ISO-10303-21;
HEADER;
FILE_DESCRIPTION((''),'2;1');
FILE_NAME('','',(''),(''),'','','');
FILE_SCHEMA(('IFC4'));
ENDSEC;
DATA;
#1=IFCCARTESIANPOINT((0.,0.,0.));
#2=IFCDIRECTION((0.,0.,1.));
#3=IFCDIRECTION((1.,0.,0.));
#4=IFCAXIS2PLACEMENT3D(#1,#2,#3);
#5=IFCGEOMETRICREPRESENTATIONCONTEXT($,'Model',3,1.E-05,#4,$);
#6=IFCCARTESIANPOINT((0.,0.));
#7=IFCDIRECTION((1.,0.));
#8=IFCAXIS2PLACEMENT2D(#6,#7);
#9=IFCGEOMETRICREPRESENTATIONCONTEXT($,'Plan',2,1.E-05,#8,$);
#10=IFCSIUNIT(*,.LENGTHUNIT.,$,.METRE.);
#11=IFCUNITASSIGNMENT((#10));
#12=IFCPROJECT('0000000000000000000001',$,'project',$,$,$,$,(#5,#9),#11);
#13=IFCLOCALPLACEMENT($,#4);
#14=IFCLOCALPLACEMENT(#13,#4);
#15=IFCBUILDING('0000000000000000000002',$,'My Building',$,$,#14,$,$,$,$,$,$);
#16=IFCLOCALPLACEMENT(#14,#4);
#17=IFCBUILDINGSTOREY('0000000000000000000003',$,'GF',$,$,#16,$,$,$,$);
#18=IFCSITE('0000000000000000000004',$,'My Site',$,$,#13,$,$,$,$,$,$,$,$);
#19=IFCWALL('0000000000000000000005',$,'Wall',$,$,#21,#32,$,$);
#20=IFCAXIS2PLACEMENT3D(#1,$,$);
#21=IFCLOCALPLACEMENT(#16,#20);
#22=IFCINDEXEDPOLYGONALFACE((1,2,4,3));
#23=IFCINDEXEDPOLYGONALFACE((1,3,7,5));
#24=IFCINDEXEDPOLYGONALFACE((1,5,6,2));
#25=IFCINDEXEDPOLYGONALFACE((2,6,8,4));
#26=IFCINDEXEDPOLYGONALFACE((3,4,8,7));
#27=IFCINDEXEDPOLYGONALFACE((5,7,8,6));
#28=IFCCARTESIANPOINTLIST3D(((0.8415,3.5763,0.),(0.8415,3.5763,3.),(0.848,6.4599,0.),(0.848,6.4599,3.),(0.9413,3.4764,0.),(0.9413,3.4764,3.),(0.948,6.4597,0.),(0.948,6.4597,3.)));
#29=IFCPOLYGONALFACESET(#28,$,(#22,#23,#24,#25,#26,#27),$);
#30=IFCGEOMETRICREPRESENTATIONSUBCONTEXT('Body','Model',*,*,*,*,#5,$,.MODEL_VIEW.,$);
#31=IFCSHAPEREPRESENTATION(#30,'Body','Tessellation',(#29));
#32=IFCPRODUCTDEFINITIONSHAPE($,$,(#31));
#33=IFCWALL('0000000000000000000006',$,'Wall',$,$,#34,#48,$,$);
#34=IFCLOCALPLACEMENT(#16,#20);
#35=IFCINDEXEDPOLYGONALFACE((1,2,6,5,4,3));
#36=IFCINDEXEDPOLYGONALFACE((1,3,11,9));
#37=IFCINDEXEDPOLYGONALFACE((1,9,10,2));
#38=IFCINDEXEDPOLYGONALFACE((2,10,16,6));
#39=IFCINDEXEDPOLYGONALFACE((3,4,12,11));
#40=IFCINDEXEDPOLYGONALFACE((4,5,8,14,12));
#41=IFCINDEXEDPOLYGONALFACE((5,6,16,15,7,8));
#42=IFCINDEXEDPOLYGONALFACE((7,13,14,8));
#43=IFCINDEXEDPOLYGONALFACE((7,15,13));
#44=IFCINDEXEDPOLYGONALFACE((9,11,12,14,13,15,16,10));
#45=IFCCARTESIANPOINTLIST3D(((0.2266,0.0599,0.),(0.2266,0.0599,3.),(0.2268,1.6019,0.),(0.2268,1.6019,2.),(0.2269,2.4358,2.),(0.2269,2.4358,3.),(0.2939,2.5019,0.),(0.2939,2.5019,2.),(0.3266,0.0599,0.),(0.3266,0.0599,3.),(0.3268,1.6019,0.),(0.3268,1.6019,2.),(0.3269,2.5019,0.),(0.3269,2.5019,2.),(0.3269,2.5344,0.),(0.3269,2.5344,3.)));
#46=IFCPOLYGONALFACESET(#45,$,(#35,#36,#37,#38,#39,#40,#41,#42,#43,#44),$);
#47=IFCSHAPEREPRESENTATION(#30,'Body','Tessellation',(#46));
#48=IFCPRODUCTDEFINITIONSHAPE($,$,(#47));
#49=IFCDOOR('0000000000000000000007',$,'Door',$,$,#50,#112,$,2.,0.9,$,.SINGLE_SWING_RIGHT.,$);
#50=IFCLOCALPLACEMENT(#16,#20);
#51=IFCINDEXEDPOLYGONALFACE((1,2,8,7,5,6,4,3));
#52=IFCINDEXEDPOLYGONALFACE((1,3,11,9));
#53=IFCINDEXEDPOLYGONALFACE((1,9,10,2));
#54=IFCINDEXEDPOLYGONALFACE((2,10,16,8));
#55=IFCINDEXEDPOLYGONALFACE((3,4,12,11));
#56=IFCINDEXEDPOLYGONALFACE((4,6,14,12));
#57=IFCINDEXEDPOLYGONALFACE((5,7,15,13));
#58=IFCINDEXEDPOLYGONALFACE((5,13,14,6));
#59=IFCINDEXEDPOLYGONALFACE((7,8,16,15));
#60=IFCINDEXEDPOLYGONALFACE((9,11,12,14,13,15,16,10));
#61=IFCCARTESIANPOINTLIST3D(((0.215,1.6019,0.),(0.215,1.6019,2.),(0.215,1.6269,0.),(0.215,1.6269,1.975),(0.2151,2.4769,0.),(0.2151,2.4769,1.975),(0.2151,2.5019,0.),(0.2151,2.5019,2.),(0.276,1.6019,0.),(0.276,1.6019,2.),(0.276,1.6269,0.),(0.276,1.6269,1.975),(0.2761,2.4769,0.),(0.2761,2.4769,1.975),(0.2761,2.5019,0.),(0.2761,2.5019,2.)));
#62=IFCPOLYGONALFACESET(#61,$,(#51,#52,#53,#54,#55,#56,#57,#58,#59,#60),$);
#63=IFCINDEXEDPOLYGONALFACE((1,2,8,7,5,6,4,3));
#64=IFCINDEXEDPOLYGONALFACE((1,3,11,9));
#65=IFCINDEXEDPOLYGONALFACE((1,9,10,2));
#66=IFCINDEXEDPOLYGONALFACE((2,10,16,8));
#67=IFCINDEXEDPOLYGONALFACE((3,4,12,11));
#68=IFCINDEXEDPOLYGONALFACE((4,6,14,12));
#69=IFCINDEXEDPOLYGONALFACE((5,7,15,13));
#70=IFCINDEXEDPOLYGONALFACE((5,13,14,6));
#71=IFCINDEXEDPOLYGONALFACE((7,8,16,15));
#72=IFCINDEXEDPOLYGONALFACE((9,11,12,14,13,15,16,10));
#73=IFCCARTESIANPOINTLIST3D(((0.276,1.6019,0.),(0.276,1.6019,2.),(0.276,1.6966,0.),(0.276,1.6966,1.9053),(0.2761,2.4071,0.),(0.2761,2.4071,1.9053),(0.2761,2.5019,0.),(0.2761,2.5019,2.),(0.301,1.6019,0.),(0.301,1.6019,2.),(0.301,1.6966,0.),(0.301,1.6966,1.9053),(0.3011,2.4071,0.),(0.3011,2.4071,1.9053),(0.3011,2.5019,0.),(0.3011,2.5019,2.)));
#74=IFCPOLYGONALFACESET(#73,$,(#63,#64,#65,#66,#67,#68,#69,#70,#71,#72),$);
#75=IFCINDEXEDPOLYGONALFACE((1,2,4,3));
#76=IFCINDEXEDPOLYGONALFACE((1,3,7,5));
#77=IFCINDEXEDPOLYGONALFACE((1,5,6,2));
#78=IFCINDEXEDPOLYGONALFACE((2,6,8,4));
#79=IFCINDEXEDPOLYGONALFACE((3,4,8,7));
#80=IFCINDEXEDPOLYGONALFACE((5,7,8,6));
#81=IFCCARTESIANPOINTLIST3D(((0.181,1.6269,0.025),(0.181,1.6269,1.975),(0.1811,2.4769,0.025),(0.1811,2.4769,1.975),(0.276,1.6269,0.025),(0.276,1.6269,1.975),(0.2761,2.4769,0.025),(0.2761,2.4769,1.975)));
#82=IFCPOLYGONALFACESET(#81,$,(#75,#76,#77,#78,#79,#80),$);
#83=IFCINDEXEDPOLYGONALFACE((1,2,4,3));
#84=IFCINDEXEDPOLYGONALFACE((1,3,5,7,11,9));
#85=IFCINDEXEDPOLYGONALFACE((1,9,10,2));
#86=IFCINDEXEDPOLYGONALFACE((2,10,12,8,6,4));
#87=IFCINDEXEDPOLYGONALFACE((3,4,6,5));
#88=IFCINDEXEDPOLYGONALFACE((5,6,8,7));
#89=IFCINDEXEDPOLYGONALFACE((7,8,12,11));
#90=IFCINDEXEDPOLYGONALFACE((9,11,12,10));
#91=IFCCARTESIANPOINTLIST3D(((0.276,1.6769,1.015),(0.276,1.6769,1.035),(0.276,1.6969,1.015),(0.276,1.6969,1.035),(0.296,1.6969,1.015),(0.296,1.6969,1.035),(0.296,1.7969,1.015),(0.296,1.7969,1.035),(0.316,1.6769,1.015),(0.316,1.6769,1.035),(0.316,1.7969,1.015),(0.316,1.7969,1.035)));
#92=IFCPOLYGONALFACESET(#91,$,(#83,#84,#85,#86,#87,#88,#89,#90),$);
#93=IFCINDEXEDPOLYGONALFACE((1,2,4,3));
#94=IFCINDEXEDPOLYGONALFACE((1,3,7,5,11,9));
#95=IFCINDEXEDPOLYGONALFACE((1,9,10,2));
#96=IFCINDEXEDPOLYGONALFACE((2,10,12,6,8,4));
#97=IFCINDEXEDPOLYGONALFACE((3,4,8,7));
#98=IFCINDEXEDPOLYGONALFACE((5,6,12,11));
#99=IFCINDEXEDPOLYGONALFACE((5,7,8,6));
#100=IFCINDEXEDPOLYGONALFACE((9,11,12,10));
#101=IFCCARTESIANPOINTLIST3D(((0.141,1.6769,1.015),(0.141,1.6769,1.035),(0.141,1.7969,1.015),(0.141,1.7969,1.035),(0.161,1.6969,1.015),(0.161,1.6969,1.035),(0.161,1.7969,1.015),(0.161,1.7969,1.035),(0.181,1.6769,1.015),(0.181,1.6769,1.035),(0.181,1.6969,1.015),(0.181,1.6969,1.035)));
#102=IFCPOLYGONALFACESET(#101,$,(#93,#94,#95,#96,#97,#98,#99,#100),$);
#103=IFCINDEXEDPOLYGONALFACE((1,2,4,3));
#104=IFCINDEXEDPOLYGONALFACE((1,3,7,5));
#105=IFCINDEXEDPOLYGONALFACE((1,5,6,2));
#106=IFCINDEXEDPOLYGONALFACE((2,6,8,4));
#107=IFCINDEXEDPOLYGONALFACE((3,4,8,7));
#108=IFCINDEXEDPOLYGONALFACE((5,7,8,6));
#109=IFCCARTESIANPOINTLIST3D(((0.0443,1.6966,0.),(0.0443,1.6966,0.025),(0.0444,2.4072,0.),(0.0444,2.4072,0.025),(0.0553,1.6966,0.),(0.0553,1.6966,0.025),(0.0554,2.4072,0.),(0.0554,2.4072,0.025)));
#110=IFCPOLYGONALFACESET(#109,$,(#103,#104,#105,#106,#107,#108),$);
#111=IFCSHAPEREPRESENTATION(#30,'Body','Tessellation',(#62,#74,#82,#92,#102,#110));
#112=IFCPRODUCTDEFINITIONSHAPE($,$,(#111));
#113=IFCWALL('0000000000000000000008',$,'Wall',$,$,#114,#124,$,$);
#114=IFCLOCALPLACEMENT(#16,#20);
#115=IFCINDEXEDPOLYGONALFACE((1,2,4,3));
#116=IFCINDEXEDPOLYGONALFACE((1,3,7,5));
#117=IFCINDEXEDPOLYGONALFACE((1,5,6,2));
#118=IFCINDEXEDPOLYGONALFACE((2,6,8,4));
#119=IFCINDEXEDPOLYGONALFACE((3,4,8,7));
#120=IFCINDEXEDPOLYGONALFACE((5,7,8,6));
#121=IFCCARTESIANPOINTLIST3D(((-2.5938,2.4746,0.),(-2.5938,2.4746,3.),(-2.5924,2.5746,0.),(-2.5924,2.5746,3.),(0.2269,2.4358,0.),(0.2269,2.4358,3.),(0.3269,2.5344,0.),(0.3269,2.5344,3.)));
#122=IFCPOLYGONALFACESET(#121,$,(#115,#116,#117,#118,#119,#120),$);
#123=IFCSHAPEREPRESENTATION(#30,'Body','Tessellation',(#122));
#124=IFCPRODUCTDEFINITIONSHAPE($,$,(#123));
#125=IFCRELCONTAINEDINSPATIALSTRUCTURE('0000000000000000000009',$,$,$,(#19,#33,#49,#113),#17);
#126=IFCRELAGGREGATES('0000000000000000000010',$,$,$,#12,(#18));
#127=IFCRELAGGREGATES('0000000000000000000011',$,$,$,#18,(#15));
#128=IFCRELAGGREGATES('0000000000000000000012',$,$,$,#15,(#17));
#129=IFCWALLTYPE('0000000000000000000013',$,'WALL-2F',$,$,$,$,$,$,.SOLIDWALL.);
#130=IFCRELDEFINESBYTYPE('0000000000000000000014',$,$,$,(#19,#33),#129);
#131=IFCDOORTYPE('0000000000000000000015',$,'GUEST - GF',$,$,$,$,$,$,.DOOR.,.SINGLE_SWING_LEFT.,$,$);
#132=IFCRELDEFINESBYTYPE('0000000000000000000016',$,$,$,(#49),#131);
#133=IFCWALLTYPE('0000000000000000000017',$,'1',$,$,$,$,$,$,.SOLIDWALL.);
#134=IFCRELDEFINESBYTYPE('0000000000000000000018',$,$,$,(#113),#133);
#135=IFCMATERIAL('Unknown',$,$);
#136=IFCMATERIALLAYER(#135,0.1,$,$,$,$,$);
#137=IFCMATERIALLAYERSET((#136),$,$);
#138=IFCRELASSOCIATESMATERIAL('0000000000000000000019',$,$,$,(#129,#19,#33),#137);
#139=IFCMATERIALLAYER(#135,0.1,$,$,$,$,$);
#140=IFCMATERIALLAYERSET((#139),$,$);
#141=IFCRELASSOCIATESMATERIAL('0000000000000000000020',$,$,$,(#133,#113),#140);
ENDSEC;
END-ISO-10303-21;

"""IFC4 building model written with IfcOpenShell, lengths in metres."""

from ifc_helpers import new_model, entity, si_unit, frame, origin_with_axes, origin_2d_with_axis, place, context, subcontext, project, spatial, line, indexed_curve, outline, extrude, shape, source, transform, mapped, material, layer, layer_set, layer_usage, type_object, type_shapes, element, fill, save


model = new_model("IFC4")

# Units and contexts
model_context = context("Model", 3, precision=1e-05, world=origin_with_axes())
plan_context = context("Plan", 2, precision=1e-05, world=origin_2d_with_axis())
body_context_1 = subcontext(model_context, "Body", "Model", "MODEL_VIEW")
body_context_2 = subcontext(plan_context, "Body", "Plan", "PLAN_VIEW")
ifc_project = project(units=[si_unit("LENGTHUNIT", "METRE")], contexts=[model_context, plan_context])

# Site, building, storey
site_placement = place(None, origin_with_axes())
site = spatial("IfcSite", under=ifc_project, at=site_placement, Name="My Site")
building_placement = place(site_placement, origin_with_axes())
building = spatial("IfcBuilding", under=site, at=building_placement, Name="My Building")
storey_placement = place(building_placement, origin_with_axes())
storey = spatial("IfcBuildingStorey", under=building, at=storey_placement, Name="GF")

# Shared definitions
ifc_material_1 = material(Name="Unknown")

# Shared definitions
ifc_layer_1 = layer(ifc_material_1, 0.1)
ifc_layer_set_1 = layer_set([ifc_layer_1])
wall_type_1 = type_object("IfcWallType", Name="WALL-2F", PredefinedType="SOLIDWALL", material=ifc_layer_set_1)

# Wall
ifc_layer_usage_1 = layer_usage(ifc_layer_set_1, "AXIS2", "POSITIVE", 0.0)
wall_1_placement = place(storey_placement, frame((0.848, 6.4599, 0.0), z_axis=(0.0, 0.0, 1.0), x_axis=(-0.00226, -0.999997, 0.0)))
element("IfcWall", 1, at=wall_1_placement, inside=storey, type_object=wall_type_1, material=ifc_layer_usage_1, Name="Wall", context=body_context_1, shape_type="SweptSolid", body=[
    extrude(outline(indexed_curve([(0.0, 0.0), (0.0, 0.1), (2.9833, 0.1), (2.8836, 0.0)], segments=[line(1, 2, 3, 4, 1)])), origin_with_axes(), (0.0, 0.0, 1.0), 3.0),
])

# Wall, opening, door
ifc_layer_usage_2 = layer_usage(ifc_layer_set_1, "AXIS2", "POSITIVE", 0.0)
wall_2_placement = place(storey_placement, frame((0.2269, 2.5358, 0.0), z_axis=(0.0, 0.0, 1.0), x_axis=(-0.000105, -1.0, 0.0)))
wall_2 = element("IfcWall", 2, at=wall_2_placement, inside=storey, type_object=wall_type_1, material=ifc_layer_usage_2, Name="Wall", context=body_context_1, shape_type="SweptSolid", body=[
    extrude(outline(indexed_curve([(0.1, 0.0), (0.0014, 0.1), (2.4759, 0.1), (2.4759, 0.0)], segments=[line(1, 2, 3, 4, 1)])), origin_with_axes(), (0.0, 0.0, 1.0), 3.0),
])
shared_shape_1 = source(origin_with_axes(), body_context_1, "Body", "SweptSolid", [
    extrude(outline(indexed_curve([(0.0, 0.0), (0.9, 0.0), (0.9, 2.0), (0.0, 2.0)], segments=[line(1, 2, 3, 4, 1)])), frame((0.0, -0.6, 0.0), z_axis=(0.0, -1.0, 0.0), x_axis=(1.0, 0.0, 0.0)), (0.0, 0.0, -1.0), 1.2),
])
opening_1_placement = place(wall_2_placement, frame((0.9339, 0.2103, 0.0), z_axis=(0.0, 0.0, 1.0), x_axis=(-1.0, 0.0, 0.0)))
opening_1 = element("IfcOpeningElement", 3, at=opening_1_placement, cuts=wall_2, PredefinedType="OPENING", context=body_context_1, shape_type="MappedRepresentation", body=[
    mapped(shared_shape_1, transform((0.0, 0.0, 0.0), x_axis=(1.0, 0.0, 0.0), y_axis=(0.0, 1.0, 0.0), z_axis=(0.0, 0.0, 1.0), scale=1.0)),
])
door_type_1 = type_object("IfcDoorType", Name="GUEST - GF", OperationType="SINGLE_SWING_LEFT", PredefinedType="DOOR")
shared_shape_2 = source(origin_with_axes(), body_context_1, "Body", "SweptSolid", [
    extrude(outline(indexed_curve([(0.0, 0.0), (0.0, 2.0), (0.9, 2.0), (0.9, 0.0), (0.875, 0.0), (0.875, 1.975), (0.025, 1.975), (0.025, 0.0)], segments=[line(1, 2, 3, 4, 5, 6, 7, 8, 1)])), frame((0.0, 0.0093, 0.0), z_axis=(0.0, -1.0, 0.0), x_axis=(1.0, 0.0, 0.0)), (0.0, 0.0, -1.0), 0.061),
    extrude(outline(indexed_curve([(0.0, 0.0), (0.0, 2.0), (0.9, 2.0), (0.9, 0.0), (0.8053, 0.0), (0.8053, 1.9053), (0.0947, 1.9053), (0.0947, 0.0)], segments=[line(1, 2, 3, 4, 5, 6, 7, 8, 1)])), frame((0.0, -0.0157, 0.0), z_axis=(0.0, -1.0, 0.0), x_axis=(1.0, 0.0, 0.0)), (0.0, 0.0, -1.0), 0.025),
    extrude(outline(indexed_curve([(0.0, 0.0), (0.85, 0.0), (0.85, 0.095), (0.0, 0.095)], segments=[line(1, 2, 3, 4, 1)])), frame((0.025, 0.0093, 0.025), z_axis=(0.0, 0.0, 1.0), x_axis=(1.0, 0.0, 0.0)), (0.0, 0.0, 1.0), 1.95),
    extrude(outline(indexed_curve([(0.0, 0.0), (0.0, -0.04), (0.12, -0.04), (0.12, -0.02), (0.02, -0.02), (0.02, 0.0)], segments=[line(1, 2, 3, 4, 5, 6, 1)])), frame((0.075, 0.0093, 1.015), z_axis=(0.0, 0.0, 1.0), x_axis=(1.0, 0.0, 0.0)), (0.0, 0.0, 1.0), 0.02),
    extrude(outline(indexed_curve([(0.0, 0.0), (0.0, 0.04), (0.12, 0.04), (0.12, 0.02), (0.02, 0.02), (0.02, 0.0)], segments=[line(1, 2, 3, 4, 5, 6, 1)])), frame((0.075, 0.1043, 1.015), z_axis=(0.0, 0.0, 1.0), x_axis=(1.0, 0.0, 0.0)), (0.0, 0.0, 1.0), 0.02),
    extrude(outline(indexed_curve([(0.0, 0.0), (0.7105, 0.0), (0.7105, 0.011), (0.0, 0.011)], segments=[line(1, 2, 3, 4, 1)])), frame((0.0947, 0.23, 0.0), z_axis=(0.0, 0.0, 1.0), x_axis=(1.0, 0.0, 0.0)), (0.0, 0.0, 1.0), 0.025),
])
shared_shape_3 = source(origin_with_axes(), body_context_2, "Body", "Curve2D", [
    entity("IfcIndexedPolyCurve", entity("IfcCartesianPointList2D", [[0.0, -0.0157], [0.0, 0.0703], [0.025, 0.0703], [0.025, 0.0093], [0.0947, 0.0093], [0.0947, -0.0157]]), [entity("IfcLineIndex", [1, 2, 3, 4, 5, 6, 1])]),
    entity("IfcIndexedPolyCurve", entity("IfcCartesianPointList2D", [[0.9, -0.0157], [0.9, 0.0703], [0.875, 0.0703], [0.875, 0.0093], [0.8053, 0.0093], [0.8053, -0.0157]]), [entity("IfcLineIndex", [1, 2, 3, 4, 5, 6, 1])]),
    entity("IfcTrimmedCurve", entity("IfcEllipse", entity("IfcAxis2Placement2D", entity("IfcCartesianPoint", [0.78, 0.0703]), entity("IfcDirection", [1.0, 0.0])), 0.755, 0.85), [entity("IfcCartesianPoint", [0.78, 0.9203])], [entity("IfcCartesianPoint", [0.025, 0.0703])], True, "CARTESIAN"),
    entity("IfcIndexedPolyCurve", entity("IfcCartesianPointList2D", [[0.875, 0.0703], [0.78, 0.0703], [0.78, 0.9203], [0.875, 0.9203]]), [entity("IfcLineIndex", [1, 2, 3, 4, 1])]),
])
type_shapes(door_type_1, [shared_shape_2, shared_shape_3])
door_1_placement = place(opening_1_placement, frame((0.0, 0.1518, 0.0), z_axis=(0.0, 0.0, 1.0), x_axis=(1.0, 0.0, 0.0)))
door_1 = element("IfcDoor", 4, at=door_1_placement, inside=storey, type_object=door_type_1, Name="Door", OperationType="SINGLE_SWING_RIGHT", OverallHeight=2.0, OverallWidth=0.9, shapes=[
    shape(body_context_1, "Body", "MappedRepresentation", [mapped(shared_shape_2, transform((0.0, 0.0, 0.0), x_axis=(1.0, 0.0, 0.0), y_axis=(0.0, 1.0, 0.0), z_axis=(0.0, 0.0, 1.0), scale=1.0))]),
    shape(body_context_2, "Body", "MappedRepresentation", [mapped(shared_shape_3, transform((0.0, 0.0, 0.0), x_axis=(1.0, 0.0, 0.0), y_axis=(0.0, 1.0, 0.0), z_axis=(0.0, 0.0, 1.0), scale=1.0))]),
])
fill(opening_1, door_1)

# Wall
ifc_layer_2 = layer(ifc_material_1, 0.1)
ifc_layer_set_2 = layer_set([ifc_layer_2])
ifc_layer_usage_3 = layer_usage(ifc_layer_set_2, "AXIS2", "POSITIVE", 0.0)
wall_type_2 = type_object("IfcWallType", Name="1", PredefinedType="SOLIDWALL", material=ifc_layer_set_2)
wall_3_placement = place(storey_placement, frame((0.2269, 2.5358, 0.0), z_axis=(0.0, 0.0, 1.0), x_axis=(-0.999905, 0.013761, 0.0)))
element("IfcWall", 5, at=wall_3_placement, inside=storey, type_object=wall_type_2, material=ifc_layer_usage_3, Name="Wall", context=body_context_1, shape_type="SweptSolid", body=[
    extrude(outline(indexed_curve([(-0.1, 0.0), (-0.0014, 0.1), (2.8195, 0.1), (2.8195, 0.0)], segments=[line(1, 2, 3, 4, 1)])), origin_with_axes(), (0.0, 0.0, 1.0), 3.0),
])

save(model, "model.ifc")
